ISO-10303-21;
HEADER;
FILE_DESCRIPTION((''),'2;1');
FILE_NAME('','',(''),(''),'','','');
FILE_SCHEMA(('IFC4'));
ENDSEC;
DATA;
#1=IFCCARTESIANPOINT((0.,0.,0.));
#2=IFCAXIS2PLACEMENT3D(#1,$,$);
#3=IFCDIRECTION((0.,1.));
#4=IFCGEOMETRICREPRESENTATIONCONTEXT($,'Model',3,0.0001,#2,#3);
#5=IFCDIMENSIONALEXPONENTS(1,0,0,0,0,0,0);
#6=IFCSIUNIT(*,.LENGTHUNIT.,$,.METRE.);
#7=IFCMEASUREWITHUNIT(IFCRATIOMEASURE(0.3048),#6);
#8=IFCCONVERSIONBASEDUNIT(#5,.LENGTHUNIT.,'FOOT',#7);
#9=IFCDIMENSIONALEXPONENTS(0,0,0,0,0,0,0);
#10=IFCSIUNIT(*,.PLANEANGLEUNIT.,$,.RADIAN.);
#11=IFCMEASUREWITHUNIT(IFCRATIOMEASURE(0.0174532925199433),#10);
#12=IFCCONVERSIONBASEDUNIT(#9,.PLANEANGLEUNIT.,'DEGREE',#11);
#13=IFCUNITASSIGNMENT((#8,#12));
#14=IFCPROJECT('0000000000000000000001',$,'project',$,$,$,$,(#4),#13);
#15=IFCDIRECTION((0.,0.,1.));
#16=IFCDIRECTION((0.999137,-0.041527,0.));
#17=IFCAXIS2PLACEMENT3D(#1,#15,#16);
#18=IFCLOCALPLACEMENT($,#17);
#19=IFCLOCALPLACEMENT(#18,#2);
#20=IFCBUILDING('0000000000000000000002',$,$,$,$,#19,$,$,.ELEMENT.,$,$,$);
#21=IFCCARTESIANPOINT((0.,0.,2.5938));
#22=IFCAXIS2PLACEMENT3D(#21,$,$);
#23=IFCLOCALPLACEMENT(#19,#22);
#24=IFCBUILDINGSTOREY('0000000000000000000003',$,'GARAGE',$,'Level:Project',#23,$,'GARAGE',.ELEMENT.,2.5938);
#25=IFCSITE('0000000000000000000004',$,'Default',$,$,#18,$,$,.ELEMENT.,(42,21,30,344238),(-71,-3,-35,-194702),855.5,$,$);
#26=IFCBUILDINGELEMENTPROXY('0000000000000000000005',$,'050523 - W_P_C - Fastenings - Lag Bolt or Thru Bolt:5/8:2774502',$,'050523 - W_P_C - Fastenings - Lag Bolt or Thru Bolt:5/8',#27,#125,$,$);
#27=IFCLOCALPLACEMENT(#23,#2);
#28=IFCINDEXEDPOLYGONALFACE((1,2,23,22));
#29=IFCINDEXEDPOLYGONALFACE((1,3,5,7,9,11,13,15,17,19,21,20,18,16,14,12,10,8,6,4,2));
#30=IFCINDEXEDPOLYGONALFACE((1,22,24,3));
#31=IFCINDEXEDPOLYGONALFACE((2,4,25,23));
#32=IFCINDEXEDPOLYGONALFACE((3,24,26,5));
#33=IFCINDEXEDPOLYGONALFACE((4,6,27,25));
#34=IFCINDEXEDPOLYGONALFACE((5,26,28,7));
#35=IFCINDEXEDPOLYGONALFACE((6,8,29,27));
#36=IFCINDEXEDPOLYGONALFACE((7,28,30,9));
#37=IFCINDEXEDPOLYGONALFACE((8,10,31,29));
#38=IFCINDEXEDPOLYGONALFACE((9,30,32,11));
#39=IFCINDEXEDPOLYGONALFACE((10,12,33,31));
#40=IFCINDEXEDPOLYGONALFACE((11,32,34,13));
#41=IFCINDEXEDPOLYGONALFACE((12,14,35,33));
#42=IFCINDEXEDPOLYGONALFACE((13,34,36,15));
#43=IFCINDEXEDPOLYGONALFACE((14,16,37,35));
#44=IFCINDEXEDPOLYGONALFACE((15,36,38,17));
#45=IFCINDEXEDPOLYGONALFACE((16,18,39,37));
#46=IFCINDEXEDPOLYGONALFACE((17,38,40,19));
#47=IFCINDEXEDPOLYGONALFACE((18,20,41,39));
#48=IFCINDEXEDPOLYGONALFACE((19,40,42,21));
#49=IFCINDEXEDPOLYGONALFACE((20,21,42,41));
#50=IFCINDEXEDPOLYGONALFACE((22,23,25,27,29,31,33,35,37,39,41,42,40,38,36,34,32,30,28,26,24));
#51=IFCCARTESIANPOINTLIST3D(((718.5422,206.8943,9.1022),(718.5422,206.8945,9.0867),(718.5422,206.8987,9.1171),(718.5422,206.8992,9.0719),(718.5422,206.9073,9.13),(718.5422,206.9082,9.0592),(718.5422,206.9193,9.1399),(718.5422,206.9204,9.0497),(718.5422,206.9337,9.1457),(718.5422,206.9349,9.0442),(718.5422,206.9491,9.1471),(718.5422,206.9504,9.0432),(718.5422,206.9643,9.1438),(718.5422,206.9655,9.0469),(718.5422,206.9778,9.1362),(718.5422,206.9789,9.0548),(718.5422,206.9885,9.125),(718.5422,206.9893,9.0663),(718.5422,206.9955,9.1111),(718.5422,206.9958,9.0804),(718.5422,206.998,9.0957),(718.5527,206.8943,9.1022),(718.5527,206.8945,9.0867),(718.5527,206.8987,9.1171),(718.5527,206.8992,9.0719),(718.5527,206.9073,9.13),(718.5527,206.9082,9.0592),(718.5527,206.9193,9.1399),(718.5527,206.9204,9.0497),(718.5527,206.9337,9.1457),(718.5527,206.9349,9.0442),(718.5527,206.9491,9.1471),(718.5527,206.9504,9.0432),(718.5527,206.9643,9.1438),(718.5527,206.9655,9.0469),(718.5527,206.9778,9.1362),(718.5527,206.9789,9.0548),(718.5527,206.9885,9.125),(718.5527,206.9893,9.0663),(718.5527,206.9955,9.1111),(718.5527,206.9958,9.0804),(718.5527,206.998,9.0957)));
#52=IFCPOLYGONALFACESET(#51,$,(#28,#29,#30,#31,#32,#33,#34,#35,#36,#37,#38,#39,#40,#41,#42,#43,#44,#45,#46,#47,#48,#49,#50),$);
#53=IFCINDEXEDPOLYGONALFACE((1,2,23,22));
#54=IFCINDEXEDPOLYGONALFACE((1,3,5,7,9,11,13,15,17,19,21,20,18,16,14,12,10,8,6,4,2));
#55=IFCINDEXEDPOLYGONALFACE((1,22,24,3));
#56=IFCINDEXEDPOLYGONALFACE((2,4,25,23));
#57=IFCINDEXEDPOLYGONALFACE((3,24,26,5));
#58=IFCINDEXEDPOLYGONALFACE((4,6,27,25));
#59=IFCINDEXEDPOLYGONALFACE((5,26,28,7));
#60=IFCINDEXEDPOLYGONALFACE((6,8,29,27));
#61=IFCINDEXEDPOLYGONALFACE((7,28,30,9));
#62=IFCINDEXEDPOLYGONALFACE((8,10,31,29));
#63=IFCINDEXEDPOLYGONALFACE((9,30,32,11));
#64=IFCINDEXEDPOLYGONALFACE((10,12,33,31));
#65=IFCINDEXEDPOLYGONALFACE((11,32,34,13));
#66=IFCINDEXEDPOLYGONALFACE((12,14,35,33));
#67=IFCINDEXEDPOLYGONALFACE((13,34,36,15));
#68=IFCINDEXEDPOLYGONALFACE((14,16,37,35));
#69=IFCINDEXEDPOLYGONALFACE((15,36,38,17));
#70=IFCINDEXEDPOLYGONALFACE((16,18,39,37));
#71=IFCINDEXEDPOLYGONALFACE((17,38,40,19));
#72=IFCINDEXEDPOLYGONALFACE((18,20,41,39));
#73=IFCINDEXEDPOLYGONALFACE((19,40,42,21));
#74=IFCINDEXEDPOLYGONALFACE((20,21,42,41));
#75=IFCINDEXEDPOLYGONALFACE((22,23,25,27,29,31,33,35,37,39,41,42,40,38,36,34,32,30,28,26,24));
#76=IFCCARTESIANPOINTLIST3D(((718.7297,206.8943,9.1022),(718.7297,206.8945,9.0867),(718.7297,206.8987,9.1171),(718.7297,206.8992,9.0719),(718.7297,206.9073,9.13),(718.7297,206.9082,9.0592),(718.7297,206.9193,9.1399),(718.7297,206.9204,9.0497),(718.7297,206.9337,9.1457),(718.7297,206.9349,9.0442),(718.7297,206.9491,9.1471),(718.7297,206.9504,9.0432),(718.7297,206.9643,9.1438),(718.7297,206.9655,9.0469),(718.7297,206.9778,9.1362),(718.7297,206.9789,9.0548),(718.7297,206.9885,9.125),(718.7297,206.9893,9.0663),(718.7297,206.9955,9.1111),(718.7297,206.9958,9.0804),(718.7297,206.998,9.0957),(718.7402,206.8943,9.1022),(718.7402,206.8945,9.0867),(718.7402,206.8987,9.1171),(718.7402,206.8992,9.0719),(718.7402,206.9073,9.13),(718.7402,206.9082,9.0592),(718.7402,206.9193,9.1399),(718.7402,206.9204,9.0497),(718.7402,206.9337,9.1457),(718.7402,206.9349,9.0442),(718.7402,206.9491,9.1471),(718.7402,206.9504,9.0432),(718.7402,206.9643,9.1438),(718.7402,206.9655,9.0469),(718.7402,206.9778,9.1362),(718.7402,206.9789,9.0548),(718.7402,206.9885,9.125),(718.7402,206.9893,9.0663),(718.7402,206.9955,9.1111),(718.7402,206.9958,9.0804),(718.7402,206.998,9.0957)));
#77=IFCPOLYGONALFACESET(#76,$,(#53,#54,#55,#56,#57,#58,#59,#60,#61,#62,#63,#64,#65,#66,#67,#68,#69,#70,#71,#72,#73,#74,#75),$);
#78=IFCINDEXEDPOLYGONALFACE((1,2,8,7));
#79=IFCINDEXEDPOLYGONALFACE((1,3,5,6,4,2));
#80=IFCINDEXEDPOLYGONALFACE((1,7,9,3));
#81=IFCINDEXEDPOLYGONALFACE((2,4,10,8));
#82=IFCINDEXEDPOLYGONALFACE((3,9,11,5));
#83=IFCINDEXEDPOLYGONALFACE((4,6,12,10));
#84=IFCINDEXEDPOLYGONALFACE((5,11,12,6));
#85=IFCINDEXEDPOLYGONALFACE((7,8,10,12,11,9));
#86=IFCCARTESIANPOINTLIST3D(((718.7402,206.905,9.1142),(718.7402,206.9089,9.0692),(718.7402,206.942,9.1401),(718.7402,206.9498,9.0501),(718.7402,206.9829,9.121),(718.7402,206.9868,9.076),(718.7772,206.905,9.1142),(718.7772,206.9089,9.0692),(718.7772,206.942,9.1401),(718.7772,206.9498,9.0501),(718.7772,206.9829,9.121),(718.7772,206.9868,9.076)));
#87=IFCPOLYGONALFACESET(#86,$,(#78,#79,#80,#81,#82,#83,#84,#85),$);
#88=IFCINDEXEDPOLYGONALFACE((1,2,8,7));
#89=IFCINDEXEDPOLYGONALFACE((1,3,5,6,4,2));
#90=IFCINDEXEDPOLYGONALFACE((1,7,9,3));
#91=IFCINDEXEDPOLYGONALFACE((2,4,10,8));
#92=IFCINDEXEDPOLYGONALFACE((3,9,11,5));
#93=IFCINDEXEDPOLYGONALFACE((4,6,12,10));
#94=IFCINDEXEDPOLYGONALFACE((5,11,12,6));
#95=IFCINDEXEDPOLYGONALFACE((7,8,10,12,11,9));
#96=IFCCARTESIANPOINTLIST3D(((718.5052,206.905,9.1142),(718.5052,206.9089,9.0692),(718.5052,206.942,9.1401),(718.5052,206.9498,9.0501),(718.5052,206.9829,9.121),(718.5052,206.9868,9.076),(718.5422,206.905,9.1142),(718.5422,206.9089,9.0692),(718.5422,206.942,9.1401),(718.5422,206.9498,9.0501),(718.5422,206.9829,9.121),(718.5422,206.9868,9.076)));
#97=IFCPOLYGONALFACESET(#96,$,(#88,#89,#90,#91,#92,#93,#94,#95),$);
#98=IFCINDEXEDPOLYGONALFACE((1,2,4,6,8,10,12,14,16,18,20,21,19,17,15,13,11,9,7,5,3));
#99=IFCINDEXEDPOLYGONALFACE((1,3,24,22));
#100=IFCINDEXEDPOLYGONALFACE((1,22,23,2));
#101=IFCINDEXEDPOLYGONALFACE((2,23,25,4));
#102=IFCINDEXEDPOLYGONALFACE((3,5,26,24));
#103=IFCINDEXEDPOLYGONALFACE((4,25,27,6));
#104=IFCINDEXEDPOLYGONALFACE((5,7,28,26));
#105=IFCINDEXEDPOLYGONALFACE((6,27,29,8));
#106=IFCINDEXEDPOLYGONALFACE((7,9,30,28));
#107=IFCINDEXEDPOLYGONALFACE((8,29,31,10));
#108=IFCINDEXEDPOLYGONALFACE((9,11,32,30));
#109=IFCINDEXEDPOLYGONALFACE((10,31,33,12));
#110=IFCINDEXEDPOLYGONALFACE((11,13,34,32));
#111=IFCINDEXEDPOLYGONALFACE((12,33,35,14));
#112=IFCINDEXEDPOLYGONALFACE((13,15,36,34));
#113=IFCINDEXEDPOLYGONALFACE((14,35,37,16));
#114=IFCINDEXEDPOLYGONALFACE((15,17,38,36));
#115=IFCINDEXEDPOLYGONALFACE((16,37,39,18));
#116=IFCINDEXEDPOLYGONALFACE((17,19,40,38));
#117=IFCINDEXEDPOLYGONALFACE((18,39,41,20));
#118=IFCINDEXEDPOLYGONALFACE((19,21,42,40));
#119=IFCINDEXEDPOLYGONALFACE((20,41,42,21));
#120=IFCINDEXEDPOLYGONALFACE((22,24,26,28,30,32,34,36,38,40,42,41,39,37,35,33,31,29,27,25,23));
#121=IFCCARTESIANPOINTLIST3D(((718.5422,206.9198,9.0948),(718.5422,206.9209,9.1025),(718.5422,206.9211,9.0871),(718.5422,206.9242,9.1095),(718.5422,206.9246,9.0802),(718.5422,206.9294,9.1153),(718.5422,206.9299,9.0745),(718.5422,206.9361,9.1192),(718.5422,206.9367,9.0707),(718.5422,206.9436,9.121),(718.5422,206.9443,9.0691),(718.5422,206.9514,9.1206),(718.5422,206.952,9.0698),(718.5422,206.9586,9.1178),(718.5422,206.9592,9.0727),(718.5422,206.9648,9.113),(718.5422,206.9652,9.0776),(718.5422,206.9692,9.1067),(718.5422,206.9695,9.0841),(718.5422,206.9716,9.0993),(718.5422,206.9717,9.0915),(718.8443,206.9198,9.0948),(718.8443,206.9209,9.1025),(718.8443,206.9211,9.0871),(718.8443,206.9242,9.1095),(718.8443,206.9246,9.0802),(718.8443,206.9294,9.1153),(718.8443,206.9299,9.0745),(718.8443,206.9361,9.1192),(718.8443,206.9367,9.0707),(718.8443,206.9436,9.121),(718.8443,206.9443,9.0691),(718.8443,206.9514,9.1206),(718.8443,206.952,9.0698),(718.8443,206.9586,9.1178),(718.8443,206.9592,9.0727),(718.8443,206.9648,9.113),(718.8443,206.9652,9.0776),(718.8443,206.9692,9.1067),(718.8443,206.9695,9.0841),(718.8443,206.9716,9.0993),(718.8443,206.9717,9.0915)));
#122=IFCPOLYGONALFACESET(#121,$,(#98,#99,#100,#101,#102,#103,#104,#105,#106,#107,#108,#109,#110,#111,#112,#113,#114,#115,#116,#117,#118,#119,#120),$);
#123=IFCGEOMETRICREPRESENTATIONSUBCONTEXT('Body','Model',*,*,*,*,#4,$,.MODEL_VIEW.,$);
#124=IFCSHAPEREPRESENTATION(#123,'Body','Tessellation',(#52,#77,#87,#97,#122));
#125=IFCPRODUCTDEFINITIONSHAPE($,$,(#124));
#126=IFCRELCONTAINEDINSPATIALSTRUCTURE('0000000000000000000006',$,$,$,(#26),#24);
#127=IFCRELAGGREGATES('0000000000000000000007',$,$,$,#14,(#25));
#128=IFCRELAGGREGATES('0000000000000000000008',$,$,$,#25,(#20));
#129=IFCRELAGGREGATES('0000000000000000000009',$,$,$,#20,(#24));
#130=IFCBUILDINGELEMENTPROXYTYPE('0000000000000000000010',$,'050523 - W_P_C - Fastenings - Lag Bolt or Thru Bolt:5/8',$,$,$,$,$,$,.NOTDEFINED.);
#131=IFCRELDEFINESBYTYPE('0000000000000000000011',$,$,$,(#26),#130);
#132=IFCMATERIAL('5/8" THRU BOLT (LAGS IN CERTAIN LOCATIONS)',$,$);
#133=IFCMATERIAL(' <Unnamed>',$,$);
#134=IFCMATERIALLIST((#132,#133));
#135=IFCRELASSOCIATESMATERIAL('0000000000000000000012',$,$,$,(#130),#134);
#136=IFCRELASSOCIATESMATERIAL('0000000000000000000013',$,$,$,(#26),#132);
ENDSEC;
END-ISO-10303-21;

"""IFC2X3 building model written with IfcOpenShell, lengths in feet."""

from ifc_helpers import new_model, entity, si_unit, converted_unit, direction, frame, frame_2d, origin, place, context, subcontext, project, spatial, polyline, circle, outline, extrude, source, transform, mapped, material, material_list, type_object, type_shapes, element, save


model = new_model("IFC2X3")

# Units and contexts
model_context = context("Model", 3, precision=0.0001, world=origin(), true_north=direction((0.0, 1.0)))
body_context = subcontext(model_context, "Body", "Model", "MODEL_VIEW")
ifc_project = project(units=[converted_unit("LENGTHUNIT", "FOOT", entity("IfcRatioMeasure", 0.3048), si_unit("LENGTHUNIT", "METRE"), dimensions=[1, 0, 0, 0, 0, 0, 0]), converted_unit("PLANEANGLEUNIT", "DEGREE", entity("IfcRatioMeasure", 0.0174532925199433), si_unit("PLANEANGLEUNIT", "RADIAN"), dimensions=[0, 0, 0, 0, 0, 0, 0])], contexts=[model_context])

# Site, building, storey
site_placement = place(None, frame((0.0, 0.0, 0.0), z_axis=(0.0, 0.0, 1.0), x_axis=(0.999137, -0.041527, 0.0)))
site = spatial("IfcSite", under=ifc_project, at=site_placement, Name="Default", CompositionType="ELEMENT", RefLatitude=(42, 21, 30, 344238), RefLongitude=(-71, -3, -35, -194702), RefElevation=855.5)
building_placement = place(site_placement, origin())
building = spatial("IfcBuilding", under=site, at=building_placement, CompositionType="ELEMENT")
storey_placement = place(building_placement, frame((0.0, 0.0, 2.5938)))
storey = spatial("IfcBuildingStorey", under=building, at=storey_placement, Name="GARAGE", ObjectType="Level:Project", LongName="GARAGE", CompositionType="ELEMENT", Elevation=2.5938)

# Building element proxy
ifc_material_1 = material(Name="5/8\" THRU BOLT (LAGS IN CERTAIN LOCATIONS)")
ifc_material_2 = material(Name=" <Unnamed>")
ifc_material_list_1 = material_list([ifc_material_1, ifc_material_2])
building_element_proxy_type_1 = type_object("IfcBuildingElementProxyType", Name="050523 - W_P_C - Fastenings - Lag Bolt or Thru Bolt:5/8", PredefinedType="NOTDEFINED", material=ifc_material_list_1)
shared_shape_1 = source(origin(), body_context, "Body", "SweptSolid", [
    extrude(circle(Radius=0.0521, at=frame_2d((0.0, 0.0), x_axis=(1.0, 0.0))), frame((0.0, 0.0, 0.0), z_axis=(0.0, 0.0, 1.0), x_axis=(0.0, -1.0, 0.0)), (0.0, 0.0, 1.0), 0.0104),
    extrude(circle(Radius=0.0521, at=frame_2d((0.0, 0.0), x_axis=(1.0, 0.0))), frame((0.0, 0.0, -0.1875), z_axis=(0.0, 0.0, 1.0), x_axis=(0.0, -1.0, 0.0)), (0.0, 0.0, 1.0), 0.0104),
    extrude(outline(polyline([(-0.0226, -0.0391), (0.0226, -0.0391), (0.0451, 0.0), (0.0226, 0.0391), (-0.0226, 0.0391), (-0.0451, 0.0), (-0.0226, -0.0391)])), frame((0.0, 0.0, -0.2245), z_axis=(0.0, 0.0, 1.0), x_axis=(0.866025, -0.5, 0.0)), (0.0, 0.0, 1.0), 0.037),
    extrude(outline(polyline([(-0.0226, -0.0391), (0.0226, -0.0391), (0.0451, 0.0), (0.0226, 0.0391), (-0.0226, 0.0391), (-0.0451, 0.0), (-0.0226, -0.0391)])), frame((0.0, 0.0, 0.0104), z_axis=(0.0, 0.0, 1.0), x_axis=(0.0, -1.0, 0.0)), (0.0, 0.0, 1.0), 0.037),
    extrude(circle(Radius=0.026, at=frame_2d((0.0, 0.0), x_axis=(1.0, 0.0))), frame((0.0, 0.0, -0.2917), z_axis=(0.0, 0.0, 1.0), x_axis=(0.0, 1.0, 0.0)), (0.0, 0.0, 1.0), 0.3021),
])
type_shapes(building_element_proxy_type_1, [shared_shape_1])
for number, where, z_axis, x_axis, name in (
    (1, (718.5527, 206.9459, 9.0951), (-1.0, 0.0, 0.0), (0.0, -0.996195, -0.087156), "050523 - W_P_C - Fastenings - Lag Bolt or Thru Bolt:5/8:2774502"),
):
    element("IfcBuildingElementProxy", number, at=place(storey_placement, frame(where, z_axis=z_axis, x_axis=x_axis)), inside=storey, type_object=building_element_proxy_type_1, material=ifc_material_1, Name=name, ObjectType="050523 - W_P_C - Fastenings - Lag Bolt or Thru Bolt:5/8", context=body_context, shape_type="MappedRepresentation", body=[
        mapped(shared_shape_1, transform((0.0, 0.0, 0.0), scale=1.0)),
    ])

save(model, "model.ifc")
